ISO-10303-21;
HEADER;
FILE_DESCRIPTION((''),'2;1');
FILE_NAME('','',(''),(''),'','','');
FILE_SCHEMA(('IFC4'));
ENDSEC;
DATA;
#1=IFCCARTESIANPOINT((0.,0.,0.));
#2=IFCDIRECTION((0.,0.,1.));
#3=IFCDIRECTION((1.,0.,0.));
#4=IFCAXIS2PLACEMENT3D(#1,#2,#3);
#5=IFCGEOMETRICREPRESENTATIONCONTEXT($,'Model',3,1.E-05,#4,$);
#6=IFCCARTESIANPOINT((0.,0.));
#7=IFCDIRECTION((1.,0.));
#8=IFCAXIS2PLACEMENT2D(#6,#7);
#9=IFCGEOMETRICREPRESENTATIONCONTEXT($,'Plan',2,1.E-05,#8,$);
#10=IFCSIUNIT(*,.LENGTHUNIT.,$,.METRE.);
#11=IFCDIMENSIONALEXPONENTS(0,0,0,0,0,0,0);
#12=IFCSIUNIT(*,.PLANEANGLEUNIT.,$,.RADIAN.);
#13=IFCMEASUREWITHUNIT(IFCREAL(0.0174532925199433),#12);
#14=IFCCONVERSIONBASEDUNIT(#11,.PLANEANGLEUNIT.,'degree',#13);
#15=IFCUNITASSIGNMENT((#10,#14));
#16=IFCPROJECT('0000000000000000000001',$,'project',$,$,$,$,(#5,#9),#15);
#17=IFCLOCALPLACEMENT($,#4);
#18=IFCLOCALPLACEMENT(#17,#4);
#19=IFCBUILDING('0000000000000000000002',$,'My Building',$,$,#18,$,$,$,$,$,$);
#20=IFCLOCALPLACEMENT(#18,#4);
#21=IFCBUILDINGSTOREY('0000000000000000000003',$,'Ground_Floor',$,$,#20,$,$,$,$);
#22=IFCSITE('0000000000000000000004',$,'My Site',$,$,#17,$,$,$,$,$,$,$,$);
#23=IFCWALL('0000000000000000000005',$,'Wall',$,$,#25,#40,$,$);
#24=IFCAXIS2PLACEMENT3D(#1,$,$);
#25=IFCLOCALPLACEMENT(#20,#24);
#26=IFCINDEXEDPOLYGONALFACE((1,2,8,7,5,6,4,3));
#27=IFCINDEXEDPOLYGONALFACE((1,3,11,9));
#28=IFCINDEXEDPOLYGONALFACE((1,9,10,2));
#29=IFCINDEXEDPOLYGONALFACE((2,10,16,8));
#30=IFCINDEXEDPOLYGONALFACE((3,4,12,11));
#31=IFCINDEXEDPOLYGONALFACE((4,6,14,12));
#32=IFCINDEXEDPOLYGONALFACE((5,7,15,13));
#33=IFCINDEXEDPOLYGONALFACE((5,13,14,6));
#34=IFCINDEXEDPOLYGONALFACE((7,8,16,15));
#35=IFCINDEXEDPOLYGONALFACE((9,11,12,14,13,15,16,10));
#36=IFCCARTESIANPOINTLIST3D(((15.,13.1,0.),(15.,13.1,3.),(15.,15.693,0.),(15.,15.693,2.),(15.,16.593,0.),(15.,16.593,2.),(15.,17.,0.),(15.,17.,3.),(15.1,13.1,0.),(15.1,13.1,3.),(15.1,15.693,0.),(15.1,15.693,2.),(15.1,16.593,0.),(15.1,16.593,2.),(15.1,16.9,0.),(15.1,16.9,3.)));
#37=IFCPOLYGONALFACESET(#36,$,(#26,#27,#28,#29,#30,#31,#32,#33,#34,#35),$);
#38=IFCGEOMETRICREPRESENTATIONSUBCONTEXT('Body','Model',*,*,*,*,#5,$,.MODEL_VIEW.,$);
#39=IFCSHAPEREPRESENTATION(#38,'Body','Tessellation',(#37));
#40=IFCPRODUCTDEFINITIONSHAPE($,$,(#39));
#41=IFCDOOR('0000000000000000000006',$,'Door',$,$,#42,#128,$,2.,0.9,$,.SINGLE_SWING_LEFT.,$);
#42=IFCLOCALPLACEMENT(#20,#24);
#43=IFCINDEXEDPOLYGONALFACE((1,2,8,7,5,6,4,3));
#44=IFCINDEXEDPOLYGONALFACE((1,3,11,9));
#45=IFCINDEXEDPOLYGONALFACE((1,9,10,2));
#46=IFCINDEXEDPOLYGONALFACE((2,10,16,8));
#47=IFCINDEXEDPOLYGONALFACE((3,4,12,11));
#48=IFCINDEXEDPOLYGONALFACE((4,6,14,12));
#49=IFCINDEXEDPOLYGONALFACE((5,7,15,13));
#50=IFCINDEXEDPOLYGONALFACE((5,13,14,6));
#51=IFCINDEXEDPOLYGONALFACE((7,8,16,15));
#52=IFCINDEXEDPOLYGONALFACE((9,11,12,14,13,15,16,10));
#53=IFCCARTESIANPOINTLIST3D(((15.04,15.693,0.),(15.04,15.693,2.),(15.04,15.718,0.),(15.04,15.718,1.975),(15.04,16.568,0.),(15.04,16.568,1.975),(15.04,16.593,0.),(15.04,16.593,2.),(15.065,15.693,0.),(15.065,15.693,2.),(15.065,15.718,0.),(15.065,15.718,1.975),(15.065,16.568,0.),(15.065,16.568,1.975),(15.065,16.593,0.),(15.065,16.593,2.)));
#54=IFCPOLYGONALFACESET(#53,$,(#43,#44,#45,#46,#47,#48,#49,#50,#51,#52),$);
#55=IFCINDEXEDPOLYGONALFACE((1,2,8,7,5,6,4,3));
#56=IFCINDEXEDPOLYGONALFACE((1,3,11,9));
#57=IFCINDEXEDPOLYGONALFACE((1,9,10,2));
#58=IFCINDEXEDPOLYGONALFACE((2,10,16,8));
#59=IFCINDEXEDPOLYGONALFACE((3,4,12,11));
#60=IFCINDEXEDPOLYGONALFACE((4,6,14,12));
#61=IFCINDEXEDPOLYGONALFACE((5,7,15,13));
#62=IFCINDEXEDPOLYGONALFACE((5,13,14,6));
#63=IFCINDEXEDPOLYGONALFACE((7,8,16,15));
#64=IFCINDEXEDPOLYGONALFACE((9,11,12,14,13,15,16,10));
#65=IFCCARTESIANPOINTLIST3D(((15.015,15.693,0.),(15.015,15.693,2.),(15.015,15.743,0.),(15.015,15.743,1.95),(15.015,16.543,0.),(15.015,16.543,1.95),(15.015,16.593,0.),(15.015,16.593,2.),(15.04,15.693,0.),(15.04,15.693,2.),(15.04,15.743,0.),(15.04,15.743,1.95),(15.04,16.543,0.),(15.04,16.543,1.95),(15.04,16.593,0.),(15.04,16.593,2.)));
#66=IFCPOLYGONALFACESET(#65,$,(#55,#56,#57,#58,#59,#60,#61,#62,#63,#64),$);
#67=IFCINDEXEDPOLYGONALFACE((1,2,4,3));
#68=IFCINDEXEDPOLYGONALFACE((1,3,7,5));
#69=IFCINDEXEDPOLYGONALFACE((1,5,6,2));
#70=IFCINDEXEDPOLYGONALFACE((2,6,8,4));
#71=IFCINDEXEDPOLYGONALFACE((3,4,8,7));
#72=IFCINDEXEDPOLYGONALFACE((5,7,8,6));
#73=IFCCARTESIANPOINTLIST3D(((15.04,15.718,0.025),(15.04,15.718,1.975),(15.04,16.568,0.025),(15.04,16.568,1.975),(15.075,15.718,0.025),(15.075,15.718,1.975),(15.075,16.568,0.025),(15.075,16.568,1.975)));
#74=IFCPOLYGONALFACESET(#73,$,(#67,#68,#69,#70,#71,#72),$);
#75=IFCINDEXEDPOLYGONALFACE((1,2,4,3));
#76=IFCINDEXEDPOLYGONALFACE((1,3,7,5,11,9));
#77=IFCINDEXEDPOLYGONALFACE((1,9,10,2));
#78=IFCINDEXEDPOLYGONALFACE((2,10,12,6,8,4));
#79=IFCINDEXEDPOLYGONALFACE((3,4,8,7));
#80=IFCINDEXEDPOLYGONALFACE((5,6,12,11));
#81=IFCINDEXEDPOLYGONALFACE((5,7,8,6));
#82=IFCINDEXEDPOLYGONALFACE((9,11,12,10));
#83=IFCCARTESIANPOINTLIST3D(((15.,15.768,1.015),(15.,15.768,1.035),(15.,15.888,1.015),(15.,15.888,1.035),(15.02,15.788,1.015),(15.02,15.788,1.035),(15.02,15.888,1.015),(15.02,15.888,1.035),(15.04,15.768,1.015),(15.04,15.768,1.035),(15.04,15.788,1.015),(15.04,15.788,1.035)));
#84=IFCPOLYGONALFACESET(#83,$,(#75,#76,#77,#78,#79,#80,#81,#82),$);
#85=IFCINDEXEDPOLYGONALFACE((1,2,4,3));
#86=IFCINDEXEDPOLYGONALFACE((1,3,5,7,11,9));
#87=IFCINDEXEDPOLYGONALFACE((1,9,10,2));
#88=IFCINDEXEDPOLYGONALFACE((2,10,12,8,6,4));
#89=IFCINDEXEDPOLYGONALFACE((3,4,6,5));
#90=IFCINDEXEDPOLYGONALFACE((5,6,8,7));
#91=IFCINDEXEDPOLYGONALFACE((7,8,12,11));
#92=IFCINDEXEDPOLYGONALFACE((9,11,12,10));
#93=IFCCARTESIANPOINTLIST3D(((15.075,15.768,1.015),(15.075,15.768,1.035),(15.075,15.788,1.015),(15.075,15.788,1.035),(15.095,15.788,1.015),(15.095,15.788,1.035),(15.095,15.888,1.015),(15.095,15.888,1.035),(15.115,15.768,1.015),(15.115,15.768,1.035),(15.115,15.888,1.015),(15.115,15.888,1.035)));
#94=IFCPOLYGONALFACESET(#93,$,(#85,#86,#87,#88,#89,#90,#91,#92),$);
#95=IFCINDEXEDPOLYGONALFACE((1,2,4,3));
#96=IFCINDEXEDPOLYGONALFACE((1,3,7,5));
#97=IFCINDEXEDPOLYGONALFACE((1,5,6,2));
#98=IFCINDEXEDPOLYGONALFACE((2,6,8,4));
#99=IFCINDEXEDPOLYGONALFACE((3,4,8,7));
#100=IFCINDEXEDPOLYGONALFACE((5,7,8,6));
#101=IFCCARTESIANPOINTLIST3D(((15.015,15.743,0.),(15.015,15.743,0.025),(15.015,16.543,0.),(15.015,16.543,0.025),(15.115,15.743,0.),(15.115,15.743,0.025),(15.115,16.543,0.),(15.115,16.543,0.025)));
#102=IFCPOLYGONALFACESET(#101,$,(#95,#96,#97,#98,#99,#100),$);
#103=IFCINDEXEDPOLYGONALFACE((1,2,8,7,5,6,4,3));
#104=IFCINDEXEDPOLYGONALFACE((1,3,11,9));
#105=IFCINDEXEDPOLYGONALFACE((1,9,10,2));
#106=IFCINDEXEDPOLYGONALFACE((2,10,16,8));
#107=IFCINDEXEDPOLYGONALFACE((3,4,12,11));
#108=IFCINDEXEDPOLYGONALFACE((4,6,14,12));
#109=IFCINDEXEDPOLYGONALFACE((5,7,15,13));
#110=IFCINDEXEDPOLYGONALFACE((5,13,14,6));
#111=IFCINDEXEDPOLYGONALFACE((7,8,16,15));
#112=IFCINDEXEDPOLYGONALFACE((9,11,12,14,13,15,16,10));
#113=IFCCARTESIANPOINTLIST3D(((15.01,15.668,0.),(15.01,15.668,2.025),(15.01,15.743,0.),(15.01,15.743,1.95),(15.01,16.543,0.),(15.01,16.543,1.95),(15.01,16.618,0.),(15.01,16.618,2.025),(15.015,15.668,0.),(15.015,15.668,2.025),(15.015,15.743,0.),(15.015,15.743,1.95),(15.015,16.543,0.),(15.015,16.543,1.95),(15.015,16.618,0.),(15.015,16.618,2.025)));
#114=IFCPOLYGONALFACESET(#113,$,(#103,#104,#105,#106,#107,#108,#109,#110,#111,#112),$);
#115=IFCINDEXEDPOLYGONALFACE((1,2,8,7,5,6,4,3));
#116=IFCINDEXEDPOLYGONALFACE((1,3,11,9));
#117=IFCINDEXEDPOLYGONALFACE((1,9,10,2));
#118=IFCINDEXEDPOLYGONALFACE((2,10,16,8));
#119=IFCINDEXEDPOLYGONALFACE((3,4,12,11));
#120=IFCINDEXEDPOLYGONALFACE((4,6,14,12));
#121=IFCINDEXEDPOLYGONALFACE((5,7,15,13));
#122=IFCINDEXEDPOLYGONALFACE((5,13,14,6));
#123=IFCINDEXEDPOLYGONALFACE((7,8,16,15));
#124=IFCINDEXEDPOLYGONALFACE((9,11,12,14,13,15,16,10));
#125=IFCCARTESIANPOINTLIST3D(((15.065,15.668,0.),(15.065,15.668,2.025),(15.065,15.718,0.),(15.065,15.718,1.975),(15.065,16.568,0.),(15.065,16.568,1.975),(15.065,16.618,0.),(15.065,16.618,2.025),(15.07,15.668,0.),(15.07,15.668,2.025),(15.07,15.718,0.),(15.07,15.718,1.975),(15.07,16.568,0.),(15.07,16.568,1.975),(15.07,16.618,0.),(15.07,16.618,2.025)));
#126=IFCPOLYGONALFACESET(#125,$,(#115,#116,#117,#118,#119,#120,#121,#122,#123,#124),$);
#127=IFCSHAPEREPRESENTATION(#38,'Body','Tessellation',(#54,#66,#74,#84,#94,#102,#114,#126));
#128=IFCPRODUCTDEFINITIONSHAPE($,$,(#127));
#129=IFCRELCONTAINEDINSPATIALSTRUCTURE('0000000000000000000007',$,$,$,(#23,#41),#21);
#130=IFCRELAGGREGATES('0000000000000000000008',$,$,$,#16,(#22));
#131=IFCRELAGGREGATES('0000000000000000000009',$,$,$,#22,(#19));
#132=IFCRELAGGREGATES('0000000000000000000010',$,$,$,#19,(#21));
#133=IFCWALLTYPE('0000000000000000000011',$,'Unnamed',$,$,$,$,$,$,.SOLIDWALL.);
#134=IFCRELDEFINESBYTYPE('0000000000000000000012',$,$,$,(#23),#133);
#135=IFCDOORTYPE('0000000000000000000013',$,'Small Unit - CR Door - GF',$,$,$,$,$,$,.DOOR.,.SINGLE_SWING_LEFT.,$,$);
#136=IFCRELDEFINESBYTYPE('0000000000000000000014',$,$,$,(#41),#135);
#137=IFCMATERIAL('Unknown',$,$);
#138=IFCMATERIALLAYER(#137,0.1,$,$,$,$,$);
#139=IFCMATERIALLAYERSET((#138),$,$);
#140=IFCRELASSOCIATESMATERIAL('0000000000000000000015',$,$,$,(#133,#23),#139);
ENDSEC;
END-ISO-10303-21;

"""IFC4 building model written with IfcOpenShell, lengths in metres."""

from ifc_helpers import new_model, entity, si_unit, converted_unit, frame, origin_with_axes, origin_2d_with_axis, place, context, subcontext, project, spatial, line, indexed_curve, outline, extrude, shape, source, transform, mapped, material, layer, layer_set, layer_usage, type_object, type_shapes, element, fill, save


model = new_model("IFC4")

# Units and contexts
model_context = context("Model", 3, precision=1e-05, world=origin_with_axes())
plan_context = context("Plan", 2, precision=1e-05, world=origin_2d_with_axis())
body_context_1 = subcontext(model_context, "Body", "Model", "MODEL_VIEW")
body_context_2 = subcontext(plan_context, "Body", "Plan", "PLAN_VIEW")
ifc_project = project(units=[si_unit("LENGTHUNIT", "METRE"), converted_unit("PLANEANGLEUNIT", "degree", entity("IfcReal", 0.0174532925199433), si_unit("PLANEANGLEUNIT", "RADIAN"), dimensions=[0, 0, 0, 0, 0, 0, 0])], contexts=[model_context, plan_context])

# Site, building, storey
site_placement = place(None, origin_with_axes())
site = spatial("IfcSite", under=ifc_project, at=site_placement, Name="My Site")
building_placement = place(site_placement, origin_with_axes())
building = spatial("IfcBuilding", under=site, at=building_placement, Name="My Building")
storey_placement = place(building_placement, origin_with_axes())
storey = spatial("IfcBuildingStorey", under=building, at=storey_placement, Name="Ground_Floor")

# Shared definitions
ifc_material = material(Name="Unknown")
ifc_layer = layer(ifc_material, 0.1)
ifc_layer_set = layer_set([ifc_layer])
wall_type = type_object("IfcWallType", Name="Unnamed", PredefinedType="SOLIDWALL", material=ifc_layer_set)

# Wall, opening, door
shared_shape_1 = source(origin_with_axes(), body_context_1, "Body", "SweptSolid", [
    extrude(outline(indexed_curve([(0.0, 0.0), (0.9, 0.0), (0.9, 2.0), (0.0, 2.0)], segments=[line(1, 2, 3, 4, 1)])), frame((0.0, -0.6, 0.0), z_axis=(0.0, -1.0, 0.0), x_axis=(1.0, 0.0, 0.0)), (0.0, 0.0, -1.0), 1.2),
])
door_type_1 = type_object("IfcDoorType", Name="Small Unit - CR Door - GF", OperationType="SINGLE_SWING_LEFT", PredefinedType="DOOR")
shared_shape_2 = source(origin_with_axes(), body_context_1, "Body", "SweptSolid", [
    extrude(outline(indexed_curve([(0.0, 0.0), (0.0, 2.0), (0.9, 2.0), (0.9, 0.0), (0.875, 0.0), (0.875, 1.975), (0.025, 1.975), (0.025, 0.0)], segments=[line(1, 2, 3, 4, 5, 6, 7, 8, 1)])), frame((0.0, 0.025, 0.0), z_axis=(0.0, -1.0, 0.0), x_axis=(1.0, 0.0, 0.0)), (0.0, 0.0, -1.0), 0.025),
    extrude(outline(indexed_curve([(0.0, 0.0), (0.0, 2.0), (0.9, 2.0), (0.9, 0.0), (0.85, 0.0), (0.85, 1.95), (0.05, 1.95), (0.05, 0.0)], segments=[line(1, 2, 3, 4, 5, 6, 7, 8, 1)])), frame((0.0, 0.0, 0.0), z_axis=(0.0, -1.0, 0.0), x_axis=(1.0, 0.0, 0.0)), (0.0, 0.0, -1.0), 0.025),
    extrude(outline(indexed_curve([(0.0, 0.0), (0.85, 0.0), (0.85, 0.035), (0.0, 0.035)], segments=[line(1, 2, 3, 4, 1)])), frame((0.025, 0.025, 0.025), z_axis=(0.0, 0.0, 1.0), x_axis=(1.0, 0.0, 0.0)), (0.0, 0.0, 1.0), 1.95),
    extrude(outline(indexed_curve([(0.0, 0.0), (0.0, -0.04), (-0.12, -0.04), (-0.12, -0.02), (-0.02, -0.02), (-0.02, 0.0)], segments=[line(1, 2, 3, 4, 5, 6, 1)])), frame((0.825, 0.025, 1.015), z_axis=(0.0, 0.0, 1.0), x_axis=(1.0, 0.0, 0.0)), (0.0, 0.0, 1.0), 0.02),
    extrude(outline(indexed_curve([(0.0, 0.0), (0.0, 0.04), (-0.12, 0.04), (-0.12, 0.02), (-0.02, 0.02), (-0.02, 0.0)], segments=[line(1, 2, 3, 4, 5, 6, 1)])), frame((0.825, 0.06, 1.015), z_axis=(0.0, 0.0, 1.0), x_axis=(1.0, 0.0, 0.0)), (0.0, 0.0, 1.0), 0.02),
    extrude(outline(indexed_curve([(0.0, 0.0), (0.8, 0.0), (0.8, 0.1), (0.0, 0.1)], segments=[line(1, 2, 3, 4, 1)])), frame((0.05, 0.0, 0.0), z_axis=(0.0, 0.0, 1.0), x_axis=(1.0, 0.0, 0.0)), (0.0, 0.0, 1.0), 0.025),
    extrude(outline(indexed_curve([(0.0, 0.0), (0.0, 2.025), (0.95, 2.025), (0.95, 0.0), (0.875, 0.0), (0.875, 1.95), (0.075, 1.95), (0.075, 0.0)], segments=[line(1, 2, 3, 4, 5, 6, 7, 8, 1)])), frame((-0.025, -0.005, 0.0), z_axis=(0.0, -1.0, 0.0), x_axis=(1.0, 0.0, 0.0)), (0.0, 0.0, -1.0), 0.005),
    extrude(outline(indexed_curve([(0.0, 0.0), (0.0, 2.025), (0.95, 2.025), (0.95, 0.0), (0.9, 0.0), (0.9, 1.975), (0.05, 1.975), (0.05, 0.0)], segments=[line(1, 2, 3, 4, 5, 6, 7, 8, 1)])), frame((-0.025, 0.05, 0.0), z_axis=(0.0, -1.0, 0.0), x_axis=(1.0, 0.0, 0.0)), (0.0, 0.0, -1.0), 0.005),
])
shared_shape_3 = source(origin_with_axes(), body_context_2, "Body", "Curve2D", [
    entity("IfcIndexedPolyCurve", entity("IfcCartesianPointList2D", [[0.0, 0.0], [0.0, 0.05], [0.025, 0.05], [0.025, 0.025], [0.05, 0.025], [0.05, 0.0]]), [entity("IfcLineIndex", [1, 2, 3, 4, 5, 6, 1])]),
    entity("IfcIndexedPolyCurve", entity("IfcCartesianPointList2D", [[0.9, 0.0], [0.9, 0.05], [0.875, 0.05], [0.875, 0.025], [0.85, 0.025], [0.85, 0.0]]), [entity("IfcLineIndex", [1, 2, 3, 4, 5, 6, 1])]),
    entity("IfcTrimmedCurve", entity("IfcEllipse", entity("IfcAxis2Placement2D", entity("IfcCartesianPoint", [0.06, 0.05]), entity("IfcDirection", [1.0, 0.0])), 0.815, 0.85), [entity("IfcCartesianPoint", [0.875, 0.05])], [entity("IfcCartesianPoint", [0.06, 0.9])], True, "CARTESIAN"),
    entity("IfcIndexedPolyCurve", entity("IfcCartesianPointList2D", [[0.025, 0.05], [0.06, 0.05], [0.06, 0.9], [0.025, 0.9]]), [entity("IfcLineIndex", [1, 2, 3, 4, 1])]),
])
type_shapes(door_type_1, [shared_shape_2, shared_shape_3])
ifc_layer_usage_1 = layer_usage(ifc_layer_set, "AXIS2", "POSITIVE", 0.0)
wall_1_placement = place(storey_placement, frame((15.0, 17.0, 0.0), z_axis=(0.0, 0.0, 1.0), x_axis=(0.0, -1.0, 0.0)))
wall_1 = element("IfcWall", 1, at=wall_1_placement, inside=storey, type_object=wall_type, material=ifc_layer_usage_1, Name="Wall", context=body_context_1, shape_type="SweptSolid", body=[
    extrude(outline(indexed_curve([(0.0, 0.0), (0.1, 0.1), (3.9, 0.1), (3.9, 0.0)], segments=[line(1, 2, 3, 4, 1)])), origin_with_axes(), (0.0, 0.0, 1.0), 3.0),
])
opening_1_placement = place(wall_1_placement, frame((0.407, 0.015, 0.0), z_axis=(0.0, 0.0, 1.0), x_axis=(1.0, 0.0, 0.0)))
opening_1 = element("IfcOpeningElement", 2, at=opening_1_placement, cuts=wall_1, PredefinedType="OPENING", context=body_context_1, shape_type="MappedRepresentation", body=[
    mapped(shared_shape_1, transform((0.0, 0.0, 0.0), x_axis=(1.0, 0.0, 0.0), y_axis=(0.0, 1.0, 0.0), z_axis=(0.0, 0.0, 1.0), scale=1.0)),
])
door_1_placement = place(opening_1_placement, origin_with_axes())
door_1 = element("IfcDoor", 3, at=door_1_placement, inside=storey, type_object=door_type_1, Name="Door", OperationType="SINGLE_SWING_LEFT", OverallHeight=2.0, OverallWidth=0.9, shapes=[
    shape(body_context_1, "Body", "MappedRepresentation", [mapped(shared_shape_2, transform((0.0, 0.0, 0.0), x_axis=(1.0, 0.0, 0.0), y_axis=(0.0, 1.0, 0.0), z_axis=(0.0, 0.0, 1.0), scale=1.0))]),
    shape(body_context_2, "Body", "MappedRepresentation", [mapped(shared_shape_3, transform((0.0, 0.0, 0.0), x_axis=(1.0, 0.0, 0.0), y_axis=(0.0, 1.0, 0.0), z_axis=(0.0, 0.0, 1.0), scale=1.0))]),
])
fill(opening_1, door_1)

save(model, "model.ifc")
